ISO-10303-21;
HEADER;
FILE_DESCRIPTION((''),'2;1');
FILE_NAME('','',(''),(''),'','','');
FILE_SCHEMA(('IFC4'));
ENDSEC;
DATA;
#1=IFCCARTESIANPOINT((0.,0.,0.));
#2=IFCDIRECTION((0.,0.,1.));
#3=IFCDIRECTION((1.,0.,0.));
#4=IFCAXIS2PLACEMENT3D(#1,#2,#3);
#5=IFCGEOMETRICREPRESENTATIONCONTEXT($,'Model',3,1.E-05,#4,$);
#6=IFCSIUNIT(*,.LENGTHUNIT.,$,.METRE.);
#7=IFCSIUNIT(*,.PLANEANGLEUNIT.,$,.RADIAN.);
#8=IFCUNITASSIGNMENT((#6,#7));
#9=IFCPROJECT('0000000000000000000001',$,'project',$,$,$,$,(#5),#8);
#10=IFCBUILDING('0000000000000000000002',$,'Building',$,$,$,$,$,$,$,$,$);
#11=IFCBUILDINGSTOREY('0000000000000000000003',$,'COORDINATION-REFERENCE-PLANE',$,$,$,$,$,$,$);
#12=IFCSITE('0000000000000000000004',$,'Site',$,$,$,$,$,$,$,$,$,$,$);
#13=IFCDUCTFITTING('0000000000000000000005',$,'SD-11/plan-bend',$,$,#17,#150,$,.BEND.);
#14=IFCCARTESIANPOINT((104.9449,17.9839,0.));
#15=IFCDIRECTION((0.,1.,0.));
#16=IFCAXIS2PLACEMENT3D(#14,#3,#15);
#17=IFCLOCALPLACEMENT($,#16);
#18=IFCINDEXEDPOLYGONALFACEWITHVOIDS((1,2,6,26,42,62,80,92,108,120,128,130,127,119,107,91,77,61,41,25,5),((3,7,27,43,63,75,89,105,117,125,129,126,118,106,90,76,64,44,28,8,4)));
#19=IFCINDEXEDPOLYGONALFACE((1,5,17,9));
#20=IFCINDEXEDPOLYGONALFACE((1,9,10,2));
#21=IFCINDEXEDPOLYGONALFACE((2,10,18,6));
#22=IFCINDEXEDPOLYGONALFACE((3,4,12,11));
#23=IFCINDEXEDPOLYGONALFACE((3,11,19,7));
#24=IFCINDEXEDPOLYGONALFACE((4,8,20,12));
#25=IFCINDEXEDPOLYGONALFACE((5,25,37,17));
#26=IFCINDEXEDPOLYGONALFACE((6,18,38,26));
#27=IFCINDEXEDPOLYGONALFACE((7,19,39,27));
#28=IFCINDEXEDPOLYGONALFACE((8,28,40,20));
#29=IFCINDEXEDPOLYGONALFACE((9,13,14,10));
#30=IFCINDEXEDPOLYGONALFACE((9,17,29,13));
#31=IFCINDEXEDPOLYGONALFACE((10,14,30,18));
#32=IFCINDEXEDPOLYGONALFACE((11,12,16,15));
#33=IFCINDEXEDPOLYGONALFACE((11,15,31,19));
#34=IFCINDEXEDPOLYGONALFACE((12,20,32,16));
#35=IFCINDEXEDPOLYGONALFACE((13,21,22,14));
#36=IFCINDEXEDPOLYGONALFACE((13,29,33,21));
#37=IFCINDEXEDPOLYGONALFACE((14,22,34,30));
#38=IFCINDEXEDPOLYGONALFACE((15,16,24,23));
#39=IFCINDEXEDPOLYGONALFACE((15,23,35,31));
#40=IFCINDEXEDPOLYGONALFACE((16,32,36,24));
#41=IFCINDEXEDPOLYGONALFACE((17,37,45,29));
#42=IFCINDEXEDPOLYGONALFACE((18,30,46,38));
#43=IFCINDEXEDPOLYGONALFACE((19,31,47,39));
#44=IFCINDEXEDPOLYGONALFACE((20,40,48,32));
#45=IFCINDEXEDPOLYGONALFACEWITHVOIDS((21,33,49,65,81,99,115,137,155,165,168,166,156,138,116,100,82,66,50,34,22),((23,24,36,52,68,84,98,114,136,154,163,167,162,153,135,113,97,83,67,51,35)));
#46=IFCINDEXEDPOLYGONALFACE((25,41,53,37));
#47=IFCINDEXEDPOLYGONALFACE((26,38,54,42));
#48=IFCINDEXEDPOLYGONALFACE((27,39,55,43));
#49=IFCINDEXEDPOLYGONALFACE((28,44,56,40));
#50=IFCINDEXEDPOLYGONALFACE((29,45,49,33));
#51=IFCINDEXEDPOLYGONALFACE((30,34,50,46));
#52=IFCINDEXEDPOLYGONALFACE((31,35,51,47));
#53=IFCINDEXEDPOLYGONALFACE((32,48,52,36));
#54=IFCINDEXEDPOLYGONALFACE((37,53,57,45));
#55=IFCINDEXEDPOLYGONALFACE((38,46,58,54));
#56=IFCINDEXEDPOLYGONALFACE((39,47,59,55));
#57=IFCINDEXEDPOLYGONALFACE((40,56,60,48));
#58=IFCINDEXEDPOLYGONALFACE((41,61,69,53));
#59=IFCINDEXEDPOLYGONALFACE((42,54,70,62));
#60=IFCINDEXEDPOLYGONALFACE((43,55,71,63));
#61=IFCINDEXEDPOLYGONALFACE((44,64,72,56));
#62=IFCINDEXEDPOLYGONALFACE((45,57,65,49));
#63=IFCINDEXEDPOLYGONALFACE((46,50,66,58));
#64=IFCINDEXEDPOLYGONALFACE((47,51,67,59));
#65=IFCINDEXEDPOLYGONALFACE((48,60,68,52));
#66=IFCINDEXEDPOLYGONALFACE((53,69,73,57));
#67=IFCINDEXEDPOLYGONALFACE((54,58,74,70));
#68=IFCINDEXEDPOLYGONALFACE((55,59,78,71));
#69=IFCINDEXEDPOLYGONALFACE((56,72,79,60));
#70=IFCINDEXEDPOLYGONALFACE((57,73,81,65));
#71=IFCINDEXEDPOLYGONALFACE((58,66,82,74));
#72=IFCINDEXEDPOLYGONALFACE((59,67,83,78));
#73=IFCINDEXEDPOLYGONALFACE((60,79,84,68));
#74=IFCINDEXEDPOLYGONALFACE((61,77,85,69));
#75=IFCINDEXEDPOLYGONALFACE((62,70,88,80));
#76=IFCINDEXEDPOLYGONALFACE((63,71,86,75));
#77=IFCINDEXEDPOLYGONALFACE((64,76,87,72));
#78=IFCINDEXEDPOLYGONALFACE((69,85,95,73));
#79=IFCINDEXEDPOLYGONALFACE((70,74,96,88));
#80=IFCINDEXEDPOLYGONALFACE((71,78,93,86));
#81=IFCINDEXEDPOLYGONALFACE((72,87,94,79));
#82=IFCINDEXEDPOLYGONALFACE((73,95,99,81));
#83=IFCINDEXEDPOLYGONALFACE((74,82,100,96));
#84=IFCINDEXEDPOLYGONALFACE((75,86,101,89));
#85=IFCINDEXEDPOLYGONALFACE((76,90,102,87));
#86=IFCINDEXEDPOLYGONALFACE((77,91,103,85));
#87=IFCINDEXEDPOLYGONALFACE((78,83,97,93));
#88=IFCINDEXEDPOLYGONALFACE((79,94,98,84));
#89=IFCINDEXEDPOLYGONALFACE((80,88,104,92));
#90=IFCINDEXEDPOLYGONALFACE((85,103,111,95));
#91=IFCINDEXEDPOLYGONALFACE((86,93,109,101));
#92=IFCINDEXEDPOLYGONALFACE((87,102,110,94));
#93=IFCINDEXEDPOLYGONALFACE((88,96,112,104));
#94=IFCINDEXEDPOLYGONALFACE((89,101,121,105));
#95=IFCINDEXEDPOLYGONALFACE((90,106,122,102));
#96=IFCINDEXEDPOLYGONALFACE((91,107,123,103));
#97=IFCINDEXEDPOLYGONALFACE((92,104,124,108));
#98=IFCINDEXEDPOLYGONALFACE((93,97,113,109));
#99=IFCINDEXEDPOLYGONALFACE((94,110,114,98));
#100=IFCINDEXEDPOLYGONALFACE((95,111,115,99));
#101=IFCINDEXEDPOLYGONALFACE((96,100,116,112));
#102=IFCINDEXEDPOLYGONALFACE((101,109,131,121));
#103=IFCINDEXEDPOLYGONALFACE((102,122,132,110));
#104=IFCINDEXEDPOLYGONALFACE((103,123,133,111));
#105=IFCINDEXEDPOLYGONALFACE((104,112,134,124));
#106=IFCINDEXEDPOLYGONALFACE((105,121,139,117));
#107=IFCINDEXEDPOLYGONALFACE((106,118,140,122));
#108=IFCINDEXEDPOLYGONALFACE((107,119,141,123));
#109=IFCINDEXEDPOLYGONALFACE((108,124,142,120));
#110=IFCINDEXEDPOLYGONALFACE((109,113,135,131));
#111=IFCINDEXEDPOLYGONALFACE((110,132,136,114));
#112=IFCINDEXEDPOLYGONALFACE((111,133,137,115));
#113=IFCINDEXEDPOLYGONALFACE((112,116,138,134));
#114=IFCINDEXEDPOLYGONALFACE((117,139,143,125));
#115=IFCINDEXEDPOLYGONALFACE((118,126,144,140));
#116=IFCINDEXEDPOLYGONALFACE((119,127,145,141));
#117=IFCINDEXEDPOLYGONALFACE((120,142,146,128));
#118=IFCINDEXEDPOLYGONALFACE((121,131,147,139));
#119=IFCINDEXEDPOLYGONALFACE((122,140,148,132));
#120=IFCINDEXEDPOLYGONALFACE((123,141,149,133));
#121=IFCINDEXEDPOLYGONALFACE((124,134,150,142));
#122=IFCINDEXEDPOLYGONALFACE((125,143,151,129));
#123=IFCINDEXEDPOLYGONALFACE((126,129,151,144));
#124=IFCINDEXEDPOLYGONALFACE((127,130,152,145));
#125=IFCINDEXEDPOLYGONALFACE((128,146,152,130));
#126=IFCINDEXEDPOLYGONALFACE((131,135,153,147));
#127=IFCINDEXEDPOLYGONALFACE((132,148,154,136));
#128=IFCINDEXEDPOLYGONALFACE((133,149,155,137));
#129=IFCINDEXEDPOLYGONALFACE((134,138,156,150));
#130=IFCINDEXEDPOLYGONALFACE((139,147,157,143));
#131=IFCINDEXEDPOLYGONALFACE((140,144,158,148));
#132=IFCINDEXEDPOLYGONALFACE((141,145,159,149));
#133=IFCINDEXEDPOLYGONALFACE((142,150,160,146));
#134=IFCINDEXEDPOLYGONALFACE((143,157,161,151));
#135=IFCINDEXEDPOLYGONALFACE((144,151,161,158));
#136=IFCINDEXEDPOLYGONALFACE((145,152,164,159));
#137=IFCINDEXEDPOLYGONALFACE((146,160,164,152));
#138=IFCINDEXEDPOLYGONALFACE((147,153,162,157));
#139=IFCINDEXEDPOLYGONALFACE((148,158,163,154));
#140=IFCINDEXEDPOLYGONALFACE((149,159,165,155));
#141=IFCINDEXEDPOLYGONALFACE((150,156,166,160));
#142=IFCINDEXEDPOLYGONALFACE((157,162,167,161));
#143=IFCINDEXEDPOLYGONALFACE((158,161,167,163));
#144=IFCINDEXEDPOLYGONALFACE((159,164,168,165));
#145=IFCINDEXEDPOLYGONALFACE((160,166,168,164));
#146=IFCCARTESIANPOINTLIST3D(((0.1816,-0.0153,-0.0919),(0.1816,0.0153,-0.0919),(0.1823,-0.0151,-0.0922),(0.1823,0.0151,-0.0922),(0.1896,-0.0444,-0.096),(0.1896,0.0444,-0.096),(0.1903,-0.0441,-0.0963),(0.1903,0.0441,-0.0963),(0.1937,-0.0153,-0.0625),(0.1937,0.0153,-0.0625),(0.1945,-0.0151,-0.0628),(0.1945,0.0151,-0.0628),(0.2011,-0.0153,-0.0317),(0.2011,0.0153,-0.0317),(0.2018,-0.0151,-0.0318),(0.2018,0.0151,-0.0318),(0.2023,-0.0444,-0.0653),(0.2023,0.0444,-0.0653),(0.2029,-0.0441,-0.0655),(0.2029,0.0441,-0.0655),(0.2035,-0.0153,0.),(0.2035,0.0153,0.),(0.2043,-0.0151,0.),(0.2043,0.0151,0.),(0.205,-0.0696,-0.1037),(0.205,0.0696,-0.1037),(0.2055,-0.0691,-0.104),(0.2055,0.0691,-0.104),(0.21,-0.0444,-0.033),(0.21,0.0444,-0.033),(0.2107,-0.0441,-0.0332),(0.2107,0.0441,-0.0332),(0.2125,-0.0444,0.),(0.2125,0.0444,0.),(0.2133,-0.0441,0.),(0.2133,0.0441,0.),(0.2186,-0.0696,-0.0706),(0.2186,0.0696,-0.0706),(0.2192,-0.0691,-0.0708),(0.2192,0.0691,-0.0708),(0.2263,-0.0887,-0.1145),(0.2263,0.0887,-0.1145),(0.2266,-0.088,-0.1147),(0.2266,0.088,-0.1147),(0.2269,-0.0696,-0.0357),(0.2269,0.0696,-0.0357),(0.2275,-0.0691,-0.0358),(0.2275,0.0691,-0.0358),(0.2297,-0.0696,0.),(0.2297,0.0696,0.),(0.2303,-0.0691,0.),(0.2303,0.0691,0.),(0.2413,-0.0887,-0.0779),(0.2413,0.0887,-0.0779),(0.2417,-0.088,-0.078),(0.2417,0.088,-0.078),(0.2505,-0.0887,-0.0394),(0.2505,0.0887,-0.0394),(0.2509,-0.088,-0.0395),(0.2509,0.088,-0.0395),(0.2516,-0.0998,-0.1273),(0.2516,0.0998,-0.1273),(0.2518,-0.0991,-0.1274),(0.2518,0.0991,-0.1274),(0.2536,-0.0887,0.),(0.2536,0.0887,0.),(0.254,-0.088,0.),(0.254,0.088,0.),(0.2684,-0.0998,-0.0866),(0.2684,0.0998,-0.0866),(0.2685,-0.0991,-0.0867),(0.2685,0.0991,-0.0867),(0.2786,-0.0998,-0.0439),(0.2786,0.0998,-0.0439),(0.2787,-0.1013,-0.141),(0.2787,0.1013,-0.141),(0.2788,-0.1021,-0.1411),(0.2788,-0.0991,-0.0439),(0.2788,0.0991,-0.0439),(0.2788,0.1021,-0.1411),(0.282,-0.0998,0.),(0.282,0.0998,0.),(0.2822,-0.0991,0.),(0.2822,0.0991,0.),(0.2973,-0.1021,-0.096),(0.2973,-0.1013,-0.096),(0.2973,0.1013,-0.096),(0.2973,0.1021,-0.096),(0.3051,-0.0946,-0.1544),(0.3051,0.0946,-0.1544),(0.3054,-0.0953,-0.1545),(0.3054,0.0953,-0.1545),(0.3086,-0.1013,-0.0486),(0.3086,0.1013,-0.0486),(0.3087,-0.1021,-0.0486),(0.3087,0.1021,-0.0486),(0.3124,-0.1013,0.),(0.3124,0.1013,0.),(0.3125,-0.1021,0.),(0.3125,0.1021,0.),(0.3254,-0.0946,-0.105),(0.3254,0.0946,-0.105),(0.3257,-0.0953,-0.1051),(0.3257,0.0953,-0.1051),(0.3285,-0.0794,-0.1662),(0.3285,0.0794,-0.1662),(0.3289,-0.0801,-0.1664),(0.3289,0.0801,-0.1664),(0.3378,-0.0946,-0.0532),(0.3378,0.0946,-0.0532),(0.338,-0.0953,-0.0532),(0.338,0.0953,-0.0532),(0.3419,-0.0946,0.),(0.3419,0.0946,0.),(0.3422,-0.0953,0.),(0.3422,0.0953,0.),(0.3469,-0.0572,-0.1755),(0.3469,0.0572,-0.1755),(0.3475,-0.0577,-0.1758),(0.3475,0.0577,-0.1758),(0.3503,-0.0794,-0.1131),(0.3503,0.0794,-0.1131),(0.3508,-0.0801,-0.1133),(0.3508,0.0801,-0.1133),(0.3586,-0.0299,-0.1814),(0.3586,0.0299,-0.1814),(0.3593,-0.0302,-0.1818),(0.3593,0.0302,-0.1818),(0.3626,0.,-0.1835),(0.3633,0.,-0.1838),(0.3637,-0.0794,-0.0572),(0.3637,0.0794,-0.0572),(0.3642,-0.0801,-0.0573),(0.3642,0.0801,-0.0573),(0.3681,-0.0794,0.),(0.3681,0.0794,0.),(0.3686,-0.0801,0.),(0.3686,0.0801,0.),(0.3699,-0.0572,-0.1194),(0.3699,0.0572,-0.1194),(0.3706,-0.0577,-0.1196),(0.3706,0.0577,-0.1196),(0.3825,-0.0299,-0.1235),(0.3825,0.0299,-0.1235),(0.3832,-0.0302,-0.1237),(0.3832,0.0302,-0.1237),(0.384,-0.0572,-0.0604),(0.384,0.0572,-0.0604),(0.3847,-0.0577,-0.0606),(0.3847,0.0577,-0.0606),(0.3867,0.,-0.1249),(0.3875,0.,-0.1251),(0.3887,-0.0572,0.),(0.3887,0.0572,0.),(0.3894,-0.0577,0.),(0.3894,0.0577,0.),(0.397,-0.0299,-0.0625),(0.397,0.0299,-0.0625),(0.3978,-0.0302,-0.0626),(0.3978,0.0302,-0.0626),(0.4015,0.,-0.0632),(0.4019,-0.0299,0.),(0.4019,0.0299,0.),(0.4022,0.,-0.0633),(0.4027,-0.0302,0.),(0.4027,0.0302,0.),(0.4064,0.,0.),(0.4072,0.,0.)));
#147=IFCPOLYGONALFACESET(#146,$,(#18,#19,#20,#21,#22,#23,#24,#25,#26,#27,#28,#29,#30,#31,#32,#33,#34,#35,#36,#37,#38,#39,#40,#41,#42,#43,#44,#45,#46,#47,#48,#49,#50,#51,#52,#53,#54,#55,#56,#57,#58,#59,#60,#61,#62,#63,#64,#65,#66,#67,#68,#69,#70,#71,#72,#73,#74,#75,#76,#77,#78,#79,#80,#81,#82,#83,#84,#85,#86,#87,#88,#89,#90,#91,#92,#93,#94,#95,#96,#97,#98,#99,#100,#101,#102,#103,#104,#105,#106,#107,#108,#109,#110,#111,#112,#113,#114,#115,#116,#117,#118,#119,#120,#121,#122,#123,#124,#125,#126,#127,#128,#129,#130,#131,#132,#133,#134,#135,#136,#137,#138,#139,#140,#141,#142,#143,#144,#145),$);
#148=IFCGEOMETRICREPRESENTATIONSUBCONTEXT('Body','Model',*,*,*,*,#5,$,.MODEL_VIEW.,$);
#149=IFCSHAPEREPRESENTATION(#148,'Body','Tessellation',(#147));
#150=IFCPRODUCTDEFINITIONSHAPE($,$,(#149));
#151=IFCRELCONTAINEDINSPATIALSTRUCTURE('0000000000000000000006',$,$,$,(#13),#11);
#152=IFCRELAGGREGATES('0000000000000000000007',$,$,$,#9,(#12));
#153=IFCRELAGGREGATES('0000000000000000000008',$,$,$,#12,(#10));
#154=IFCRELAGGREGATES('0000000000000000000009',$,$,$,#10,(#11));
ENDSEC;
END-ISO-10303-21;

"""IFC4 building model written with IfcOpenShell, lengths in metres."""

from ifc_helpers import new_model, entity, si_unit, frame, origin_with_axes, place, context, subcontext, project, spatial, element, save


model = new_model("IFC4")

# Units and contexts
model_context = context("Model", 3, precision=1e-05, world=origin_with_axes())
body_context_1 = subcontext(model_context, "Body", "Model", "MODEL_VIEW")
ifc_project = project(units=[si_unit("LENGTHUNIT", "METRE"), si_unit("PLANEANGLEUNIT", "RADIAN")], contexts=[model_context])

# Site, building, storey
site = spatial("IfcSite", under=ifc_project, Name="Site")
building = spatial("IfcBuilding", under=site, Name="Building")
storey = spatial("IfcBuildingStorey", under=building, Name="COORDINATION-REFERENCE-PLANE")

# Duct fitting
duct_fitting_1_placement = place(None, frame((104.9449, 17.9839, 0.0), z_axis=(1.0, 0.0, 0.0), x_axis=(0.0, 1.0, 0.0)))
element("IfcDuctFitting", 1, at=duct_fitting_1_placement, inside=storey, Name="SD-11/plan-bend", PredefinedType="BEND", context=body_context_1, shape_type="SweptSolid", body=[
    entity("IfcRevolvedAreaSolid", entity("IfcCircleHollowProfileDef", "AREA", None, entity("IfcAxis2Placement2D", entity("IfcCartesianPoint", [0.3048, 0.0])), 0.1024, 0.0008), entity("IfcAxis2Placement3D", entity("IfcCartesianPoint", [0.0, 0.0, 0.0]), entity("IfcDirection", [0.0, 0.0, 1.0]), entity("IfcDirection", [1.0, 0.0, 0.0])), entity("IfcAxis1Placement", entity("IfcCartesianPoint", [0.0, 0.0, 0.0]), entity("IfcDirection", [0.0, 1.0, 0.0])), 0.468399),
])

save(model, "model.ifc")
